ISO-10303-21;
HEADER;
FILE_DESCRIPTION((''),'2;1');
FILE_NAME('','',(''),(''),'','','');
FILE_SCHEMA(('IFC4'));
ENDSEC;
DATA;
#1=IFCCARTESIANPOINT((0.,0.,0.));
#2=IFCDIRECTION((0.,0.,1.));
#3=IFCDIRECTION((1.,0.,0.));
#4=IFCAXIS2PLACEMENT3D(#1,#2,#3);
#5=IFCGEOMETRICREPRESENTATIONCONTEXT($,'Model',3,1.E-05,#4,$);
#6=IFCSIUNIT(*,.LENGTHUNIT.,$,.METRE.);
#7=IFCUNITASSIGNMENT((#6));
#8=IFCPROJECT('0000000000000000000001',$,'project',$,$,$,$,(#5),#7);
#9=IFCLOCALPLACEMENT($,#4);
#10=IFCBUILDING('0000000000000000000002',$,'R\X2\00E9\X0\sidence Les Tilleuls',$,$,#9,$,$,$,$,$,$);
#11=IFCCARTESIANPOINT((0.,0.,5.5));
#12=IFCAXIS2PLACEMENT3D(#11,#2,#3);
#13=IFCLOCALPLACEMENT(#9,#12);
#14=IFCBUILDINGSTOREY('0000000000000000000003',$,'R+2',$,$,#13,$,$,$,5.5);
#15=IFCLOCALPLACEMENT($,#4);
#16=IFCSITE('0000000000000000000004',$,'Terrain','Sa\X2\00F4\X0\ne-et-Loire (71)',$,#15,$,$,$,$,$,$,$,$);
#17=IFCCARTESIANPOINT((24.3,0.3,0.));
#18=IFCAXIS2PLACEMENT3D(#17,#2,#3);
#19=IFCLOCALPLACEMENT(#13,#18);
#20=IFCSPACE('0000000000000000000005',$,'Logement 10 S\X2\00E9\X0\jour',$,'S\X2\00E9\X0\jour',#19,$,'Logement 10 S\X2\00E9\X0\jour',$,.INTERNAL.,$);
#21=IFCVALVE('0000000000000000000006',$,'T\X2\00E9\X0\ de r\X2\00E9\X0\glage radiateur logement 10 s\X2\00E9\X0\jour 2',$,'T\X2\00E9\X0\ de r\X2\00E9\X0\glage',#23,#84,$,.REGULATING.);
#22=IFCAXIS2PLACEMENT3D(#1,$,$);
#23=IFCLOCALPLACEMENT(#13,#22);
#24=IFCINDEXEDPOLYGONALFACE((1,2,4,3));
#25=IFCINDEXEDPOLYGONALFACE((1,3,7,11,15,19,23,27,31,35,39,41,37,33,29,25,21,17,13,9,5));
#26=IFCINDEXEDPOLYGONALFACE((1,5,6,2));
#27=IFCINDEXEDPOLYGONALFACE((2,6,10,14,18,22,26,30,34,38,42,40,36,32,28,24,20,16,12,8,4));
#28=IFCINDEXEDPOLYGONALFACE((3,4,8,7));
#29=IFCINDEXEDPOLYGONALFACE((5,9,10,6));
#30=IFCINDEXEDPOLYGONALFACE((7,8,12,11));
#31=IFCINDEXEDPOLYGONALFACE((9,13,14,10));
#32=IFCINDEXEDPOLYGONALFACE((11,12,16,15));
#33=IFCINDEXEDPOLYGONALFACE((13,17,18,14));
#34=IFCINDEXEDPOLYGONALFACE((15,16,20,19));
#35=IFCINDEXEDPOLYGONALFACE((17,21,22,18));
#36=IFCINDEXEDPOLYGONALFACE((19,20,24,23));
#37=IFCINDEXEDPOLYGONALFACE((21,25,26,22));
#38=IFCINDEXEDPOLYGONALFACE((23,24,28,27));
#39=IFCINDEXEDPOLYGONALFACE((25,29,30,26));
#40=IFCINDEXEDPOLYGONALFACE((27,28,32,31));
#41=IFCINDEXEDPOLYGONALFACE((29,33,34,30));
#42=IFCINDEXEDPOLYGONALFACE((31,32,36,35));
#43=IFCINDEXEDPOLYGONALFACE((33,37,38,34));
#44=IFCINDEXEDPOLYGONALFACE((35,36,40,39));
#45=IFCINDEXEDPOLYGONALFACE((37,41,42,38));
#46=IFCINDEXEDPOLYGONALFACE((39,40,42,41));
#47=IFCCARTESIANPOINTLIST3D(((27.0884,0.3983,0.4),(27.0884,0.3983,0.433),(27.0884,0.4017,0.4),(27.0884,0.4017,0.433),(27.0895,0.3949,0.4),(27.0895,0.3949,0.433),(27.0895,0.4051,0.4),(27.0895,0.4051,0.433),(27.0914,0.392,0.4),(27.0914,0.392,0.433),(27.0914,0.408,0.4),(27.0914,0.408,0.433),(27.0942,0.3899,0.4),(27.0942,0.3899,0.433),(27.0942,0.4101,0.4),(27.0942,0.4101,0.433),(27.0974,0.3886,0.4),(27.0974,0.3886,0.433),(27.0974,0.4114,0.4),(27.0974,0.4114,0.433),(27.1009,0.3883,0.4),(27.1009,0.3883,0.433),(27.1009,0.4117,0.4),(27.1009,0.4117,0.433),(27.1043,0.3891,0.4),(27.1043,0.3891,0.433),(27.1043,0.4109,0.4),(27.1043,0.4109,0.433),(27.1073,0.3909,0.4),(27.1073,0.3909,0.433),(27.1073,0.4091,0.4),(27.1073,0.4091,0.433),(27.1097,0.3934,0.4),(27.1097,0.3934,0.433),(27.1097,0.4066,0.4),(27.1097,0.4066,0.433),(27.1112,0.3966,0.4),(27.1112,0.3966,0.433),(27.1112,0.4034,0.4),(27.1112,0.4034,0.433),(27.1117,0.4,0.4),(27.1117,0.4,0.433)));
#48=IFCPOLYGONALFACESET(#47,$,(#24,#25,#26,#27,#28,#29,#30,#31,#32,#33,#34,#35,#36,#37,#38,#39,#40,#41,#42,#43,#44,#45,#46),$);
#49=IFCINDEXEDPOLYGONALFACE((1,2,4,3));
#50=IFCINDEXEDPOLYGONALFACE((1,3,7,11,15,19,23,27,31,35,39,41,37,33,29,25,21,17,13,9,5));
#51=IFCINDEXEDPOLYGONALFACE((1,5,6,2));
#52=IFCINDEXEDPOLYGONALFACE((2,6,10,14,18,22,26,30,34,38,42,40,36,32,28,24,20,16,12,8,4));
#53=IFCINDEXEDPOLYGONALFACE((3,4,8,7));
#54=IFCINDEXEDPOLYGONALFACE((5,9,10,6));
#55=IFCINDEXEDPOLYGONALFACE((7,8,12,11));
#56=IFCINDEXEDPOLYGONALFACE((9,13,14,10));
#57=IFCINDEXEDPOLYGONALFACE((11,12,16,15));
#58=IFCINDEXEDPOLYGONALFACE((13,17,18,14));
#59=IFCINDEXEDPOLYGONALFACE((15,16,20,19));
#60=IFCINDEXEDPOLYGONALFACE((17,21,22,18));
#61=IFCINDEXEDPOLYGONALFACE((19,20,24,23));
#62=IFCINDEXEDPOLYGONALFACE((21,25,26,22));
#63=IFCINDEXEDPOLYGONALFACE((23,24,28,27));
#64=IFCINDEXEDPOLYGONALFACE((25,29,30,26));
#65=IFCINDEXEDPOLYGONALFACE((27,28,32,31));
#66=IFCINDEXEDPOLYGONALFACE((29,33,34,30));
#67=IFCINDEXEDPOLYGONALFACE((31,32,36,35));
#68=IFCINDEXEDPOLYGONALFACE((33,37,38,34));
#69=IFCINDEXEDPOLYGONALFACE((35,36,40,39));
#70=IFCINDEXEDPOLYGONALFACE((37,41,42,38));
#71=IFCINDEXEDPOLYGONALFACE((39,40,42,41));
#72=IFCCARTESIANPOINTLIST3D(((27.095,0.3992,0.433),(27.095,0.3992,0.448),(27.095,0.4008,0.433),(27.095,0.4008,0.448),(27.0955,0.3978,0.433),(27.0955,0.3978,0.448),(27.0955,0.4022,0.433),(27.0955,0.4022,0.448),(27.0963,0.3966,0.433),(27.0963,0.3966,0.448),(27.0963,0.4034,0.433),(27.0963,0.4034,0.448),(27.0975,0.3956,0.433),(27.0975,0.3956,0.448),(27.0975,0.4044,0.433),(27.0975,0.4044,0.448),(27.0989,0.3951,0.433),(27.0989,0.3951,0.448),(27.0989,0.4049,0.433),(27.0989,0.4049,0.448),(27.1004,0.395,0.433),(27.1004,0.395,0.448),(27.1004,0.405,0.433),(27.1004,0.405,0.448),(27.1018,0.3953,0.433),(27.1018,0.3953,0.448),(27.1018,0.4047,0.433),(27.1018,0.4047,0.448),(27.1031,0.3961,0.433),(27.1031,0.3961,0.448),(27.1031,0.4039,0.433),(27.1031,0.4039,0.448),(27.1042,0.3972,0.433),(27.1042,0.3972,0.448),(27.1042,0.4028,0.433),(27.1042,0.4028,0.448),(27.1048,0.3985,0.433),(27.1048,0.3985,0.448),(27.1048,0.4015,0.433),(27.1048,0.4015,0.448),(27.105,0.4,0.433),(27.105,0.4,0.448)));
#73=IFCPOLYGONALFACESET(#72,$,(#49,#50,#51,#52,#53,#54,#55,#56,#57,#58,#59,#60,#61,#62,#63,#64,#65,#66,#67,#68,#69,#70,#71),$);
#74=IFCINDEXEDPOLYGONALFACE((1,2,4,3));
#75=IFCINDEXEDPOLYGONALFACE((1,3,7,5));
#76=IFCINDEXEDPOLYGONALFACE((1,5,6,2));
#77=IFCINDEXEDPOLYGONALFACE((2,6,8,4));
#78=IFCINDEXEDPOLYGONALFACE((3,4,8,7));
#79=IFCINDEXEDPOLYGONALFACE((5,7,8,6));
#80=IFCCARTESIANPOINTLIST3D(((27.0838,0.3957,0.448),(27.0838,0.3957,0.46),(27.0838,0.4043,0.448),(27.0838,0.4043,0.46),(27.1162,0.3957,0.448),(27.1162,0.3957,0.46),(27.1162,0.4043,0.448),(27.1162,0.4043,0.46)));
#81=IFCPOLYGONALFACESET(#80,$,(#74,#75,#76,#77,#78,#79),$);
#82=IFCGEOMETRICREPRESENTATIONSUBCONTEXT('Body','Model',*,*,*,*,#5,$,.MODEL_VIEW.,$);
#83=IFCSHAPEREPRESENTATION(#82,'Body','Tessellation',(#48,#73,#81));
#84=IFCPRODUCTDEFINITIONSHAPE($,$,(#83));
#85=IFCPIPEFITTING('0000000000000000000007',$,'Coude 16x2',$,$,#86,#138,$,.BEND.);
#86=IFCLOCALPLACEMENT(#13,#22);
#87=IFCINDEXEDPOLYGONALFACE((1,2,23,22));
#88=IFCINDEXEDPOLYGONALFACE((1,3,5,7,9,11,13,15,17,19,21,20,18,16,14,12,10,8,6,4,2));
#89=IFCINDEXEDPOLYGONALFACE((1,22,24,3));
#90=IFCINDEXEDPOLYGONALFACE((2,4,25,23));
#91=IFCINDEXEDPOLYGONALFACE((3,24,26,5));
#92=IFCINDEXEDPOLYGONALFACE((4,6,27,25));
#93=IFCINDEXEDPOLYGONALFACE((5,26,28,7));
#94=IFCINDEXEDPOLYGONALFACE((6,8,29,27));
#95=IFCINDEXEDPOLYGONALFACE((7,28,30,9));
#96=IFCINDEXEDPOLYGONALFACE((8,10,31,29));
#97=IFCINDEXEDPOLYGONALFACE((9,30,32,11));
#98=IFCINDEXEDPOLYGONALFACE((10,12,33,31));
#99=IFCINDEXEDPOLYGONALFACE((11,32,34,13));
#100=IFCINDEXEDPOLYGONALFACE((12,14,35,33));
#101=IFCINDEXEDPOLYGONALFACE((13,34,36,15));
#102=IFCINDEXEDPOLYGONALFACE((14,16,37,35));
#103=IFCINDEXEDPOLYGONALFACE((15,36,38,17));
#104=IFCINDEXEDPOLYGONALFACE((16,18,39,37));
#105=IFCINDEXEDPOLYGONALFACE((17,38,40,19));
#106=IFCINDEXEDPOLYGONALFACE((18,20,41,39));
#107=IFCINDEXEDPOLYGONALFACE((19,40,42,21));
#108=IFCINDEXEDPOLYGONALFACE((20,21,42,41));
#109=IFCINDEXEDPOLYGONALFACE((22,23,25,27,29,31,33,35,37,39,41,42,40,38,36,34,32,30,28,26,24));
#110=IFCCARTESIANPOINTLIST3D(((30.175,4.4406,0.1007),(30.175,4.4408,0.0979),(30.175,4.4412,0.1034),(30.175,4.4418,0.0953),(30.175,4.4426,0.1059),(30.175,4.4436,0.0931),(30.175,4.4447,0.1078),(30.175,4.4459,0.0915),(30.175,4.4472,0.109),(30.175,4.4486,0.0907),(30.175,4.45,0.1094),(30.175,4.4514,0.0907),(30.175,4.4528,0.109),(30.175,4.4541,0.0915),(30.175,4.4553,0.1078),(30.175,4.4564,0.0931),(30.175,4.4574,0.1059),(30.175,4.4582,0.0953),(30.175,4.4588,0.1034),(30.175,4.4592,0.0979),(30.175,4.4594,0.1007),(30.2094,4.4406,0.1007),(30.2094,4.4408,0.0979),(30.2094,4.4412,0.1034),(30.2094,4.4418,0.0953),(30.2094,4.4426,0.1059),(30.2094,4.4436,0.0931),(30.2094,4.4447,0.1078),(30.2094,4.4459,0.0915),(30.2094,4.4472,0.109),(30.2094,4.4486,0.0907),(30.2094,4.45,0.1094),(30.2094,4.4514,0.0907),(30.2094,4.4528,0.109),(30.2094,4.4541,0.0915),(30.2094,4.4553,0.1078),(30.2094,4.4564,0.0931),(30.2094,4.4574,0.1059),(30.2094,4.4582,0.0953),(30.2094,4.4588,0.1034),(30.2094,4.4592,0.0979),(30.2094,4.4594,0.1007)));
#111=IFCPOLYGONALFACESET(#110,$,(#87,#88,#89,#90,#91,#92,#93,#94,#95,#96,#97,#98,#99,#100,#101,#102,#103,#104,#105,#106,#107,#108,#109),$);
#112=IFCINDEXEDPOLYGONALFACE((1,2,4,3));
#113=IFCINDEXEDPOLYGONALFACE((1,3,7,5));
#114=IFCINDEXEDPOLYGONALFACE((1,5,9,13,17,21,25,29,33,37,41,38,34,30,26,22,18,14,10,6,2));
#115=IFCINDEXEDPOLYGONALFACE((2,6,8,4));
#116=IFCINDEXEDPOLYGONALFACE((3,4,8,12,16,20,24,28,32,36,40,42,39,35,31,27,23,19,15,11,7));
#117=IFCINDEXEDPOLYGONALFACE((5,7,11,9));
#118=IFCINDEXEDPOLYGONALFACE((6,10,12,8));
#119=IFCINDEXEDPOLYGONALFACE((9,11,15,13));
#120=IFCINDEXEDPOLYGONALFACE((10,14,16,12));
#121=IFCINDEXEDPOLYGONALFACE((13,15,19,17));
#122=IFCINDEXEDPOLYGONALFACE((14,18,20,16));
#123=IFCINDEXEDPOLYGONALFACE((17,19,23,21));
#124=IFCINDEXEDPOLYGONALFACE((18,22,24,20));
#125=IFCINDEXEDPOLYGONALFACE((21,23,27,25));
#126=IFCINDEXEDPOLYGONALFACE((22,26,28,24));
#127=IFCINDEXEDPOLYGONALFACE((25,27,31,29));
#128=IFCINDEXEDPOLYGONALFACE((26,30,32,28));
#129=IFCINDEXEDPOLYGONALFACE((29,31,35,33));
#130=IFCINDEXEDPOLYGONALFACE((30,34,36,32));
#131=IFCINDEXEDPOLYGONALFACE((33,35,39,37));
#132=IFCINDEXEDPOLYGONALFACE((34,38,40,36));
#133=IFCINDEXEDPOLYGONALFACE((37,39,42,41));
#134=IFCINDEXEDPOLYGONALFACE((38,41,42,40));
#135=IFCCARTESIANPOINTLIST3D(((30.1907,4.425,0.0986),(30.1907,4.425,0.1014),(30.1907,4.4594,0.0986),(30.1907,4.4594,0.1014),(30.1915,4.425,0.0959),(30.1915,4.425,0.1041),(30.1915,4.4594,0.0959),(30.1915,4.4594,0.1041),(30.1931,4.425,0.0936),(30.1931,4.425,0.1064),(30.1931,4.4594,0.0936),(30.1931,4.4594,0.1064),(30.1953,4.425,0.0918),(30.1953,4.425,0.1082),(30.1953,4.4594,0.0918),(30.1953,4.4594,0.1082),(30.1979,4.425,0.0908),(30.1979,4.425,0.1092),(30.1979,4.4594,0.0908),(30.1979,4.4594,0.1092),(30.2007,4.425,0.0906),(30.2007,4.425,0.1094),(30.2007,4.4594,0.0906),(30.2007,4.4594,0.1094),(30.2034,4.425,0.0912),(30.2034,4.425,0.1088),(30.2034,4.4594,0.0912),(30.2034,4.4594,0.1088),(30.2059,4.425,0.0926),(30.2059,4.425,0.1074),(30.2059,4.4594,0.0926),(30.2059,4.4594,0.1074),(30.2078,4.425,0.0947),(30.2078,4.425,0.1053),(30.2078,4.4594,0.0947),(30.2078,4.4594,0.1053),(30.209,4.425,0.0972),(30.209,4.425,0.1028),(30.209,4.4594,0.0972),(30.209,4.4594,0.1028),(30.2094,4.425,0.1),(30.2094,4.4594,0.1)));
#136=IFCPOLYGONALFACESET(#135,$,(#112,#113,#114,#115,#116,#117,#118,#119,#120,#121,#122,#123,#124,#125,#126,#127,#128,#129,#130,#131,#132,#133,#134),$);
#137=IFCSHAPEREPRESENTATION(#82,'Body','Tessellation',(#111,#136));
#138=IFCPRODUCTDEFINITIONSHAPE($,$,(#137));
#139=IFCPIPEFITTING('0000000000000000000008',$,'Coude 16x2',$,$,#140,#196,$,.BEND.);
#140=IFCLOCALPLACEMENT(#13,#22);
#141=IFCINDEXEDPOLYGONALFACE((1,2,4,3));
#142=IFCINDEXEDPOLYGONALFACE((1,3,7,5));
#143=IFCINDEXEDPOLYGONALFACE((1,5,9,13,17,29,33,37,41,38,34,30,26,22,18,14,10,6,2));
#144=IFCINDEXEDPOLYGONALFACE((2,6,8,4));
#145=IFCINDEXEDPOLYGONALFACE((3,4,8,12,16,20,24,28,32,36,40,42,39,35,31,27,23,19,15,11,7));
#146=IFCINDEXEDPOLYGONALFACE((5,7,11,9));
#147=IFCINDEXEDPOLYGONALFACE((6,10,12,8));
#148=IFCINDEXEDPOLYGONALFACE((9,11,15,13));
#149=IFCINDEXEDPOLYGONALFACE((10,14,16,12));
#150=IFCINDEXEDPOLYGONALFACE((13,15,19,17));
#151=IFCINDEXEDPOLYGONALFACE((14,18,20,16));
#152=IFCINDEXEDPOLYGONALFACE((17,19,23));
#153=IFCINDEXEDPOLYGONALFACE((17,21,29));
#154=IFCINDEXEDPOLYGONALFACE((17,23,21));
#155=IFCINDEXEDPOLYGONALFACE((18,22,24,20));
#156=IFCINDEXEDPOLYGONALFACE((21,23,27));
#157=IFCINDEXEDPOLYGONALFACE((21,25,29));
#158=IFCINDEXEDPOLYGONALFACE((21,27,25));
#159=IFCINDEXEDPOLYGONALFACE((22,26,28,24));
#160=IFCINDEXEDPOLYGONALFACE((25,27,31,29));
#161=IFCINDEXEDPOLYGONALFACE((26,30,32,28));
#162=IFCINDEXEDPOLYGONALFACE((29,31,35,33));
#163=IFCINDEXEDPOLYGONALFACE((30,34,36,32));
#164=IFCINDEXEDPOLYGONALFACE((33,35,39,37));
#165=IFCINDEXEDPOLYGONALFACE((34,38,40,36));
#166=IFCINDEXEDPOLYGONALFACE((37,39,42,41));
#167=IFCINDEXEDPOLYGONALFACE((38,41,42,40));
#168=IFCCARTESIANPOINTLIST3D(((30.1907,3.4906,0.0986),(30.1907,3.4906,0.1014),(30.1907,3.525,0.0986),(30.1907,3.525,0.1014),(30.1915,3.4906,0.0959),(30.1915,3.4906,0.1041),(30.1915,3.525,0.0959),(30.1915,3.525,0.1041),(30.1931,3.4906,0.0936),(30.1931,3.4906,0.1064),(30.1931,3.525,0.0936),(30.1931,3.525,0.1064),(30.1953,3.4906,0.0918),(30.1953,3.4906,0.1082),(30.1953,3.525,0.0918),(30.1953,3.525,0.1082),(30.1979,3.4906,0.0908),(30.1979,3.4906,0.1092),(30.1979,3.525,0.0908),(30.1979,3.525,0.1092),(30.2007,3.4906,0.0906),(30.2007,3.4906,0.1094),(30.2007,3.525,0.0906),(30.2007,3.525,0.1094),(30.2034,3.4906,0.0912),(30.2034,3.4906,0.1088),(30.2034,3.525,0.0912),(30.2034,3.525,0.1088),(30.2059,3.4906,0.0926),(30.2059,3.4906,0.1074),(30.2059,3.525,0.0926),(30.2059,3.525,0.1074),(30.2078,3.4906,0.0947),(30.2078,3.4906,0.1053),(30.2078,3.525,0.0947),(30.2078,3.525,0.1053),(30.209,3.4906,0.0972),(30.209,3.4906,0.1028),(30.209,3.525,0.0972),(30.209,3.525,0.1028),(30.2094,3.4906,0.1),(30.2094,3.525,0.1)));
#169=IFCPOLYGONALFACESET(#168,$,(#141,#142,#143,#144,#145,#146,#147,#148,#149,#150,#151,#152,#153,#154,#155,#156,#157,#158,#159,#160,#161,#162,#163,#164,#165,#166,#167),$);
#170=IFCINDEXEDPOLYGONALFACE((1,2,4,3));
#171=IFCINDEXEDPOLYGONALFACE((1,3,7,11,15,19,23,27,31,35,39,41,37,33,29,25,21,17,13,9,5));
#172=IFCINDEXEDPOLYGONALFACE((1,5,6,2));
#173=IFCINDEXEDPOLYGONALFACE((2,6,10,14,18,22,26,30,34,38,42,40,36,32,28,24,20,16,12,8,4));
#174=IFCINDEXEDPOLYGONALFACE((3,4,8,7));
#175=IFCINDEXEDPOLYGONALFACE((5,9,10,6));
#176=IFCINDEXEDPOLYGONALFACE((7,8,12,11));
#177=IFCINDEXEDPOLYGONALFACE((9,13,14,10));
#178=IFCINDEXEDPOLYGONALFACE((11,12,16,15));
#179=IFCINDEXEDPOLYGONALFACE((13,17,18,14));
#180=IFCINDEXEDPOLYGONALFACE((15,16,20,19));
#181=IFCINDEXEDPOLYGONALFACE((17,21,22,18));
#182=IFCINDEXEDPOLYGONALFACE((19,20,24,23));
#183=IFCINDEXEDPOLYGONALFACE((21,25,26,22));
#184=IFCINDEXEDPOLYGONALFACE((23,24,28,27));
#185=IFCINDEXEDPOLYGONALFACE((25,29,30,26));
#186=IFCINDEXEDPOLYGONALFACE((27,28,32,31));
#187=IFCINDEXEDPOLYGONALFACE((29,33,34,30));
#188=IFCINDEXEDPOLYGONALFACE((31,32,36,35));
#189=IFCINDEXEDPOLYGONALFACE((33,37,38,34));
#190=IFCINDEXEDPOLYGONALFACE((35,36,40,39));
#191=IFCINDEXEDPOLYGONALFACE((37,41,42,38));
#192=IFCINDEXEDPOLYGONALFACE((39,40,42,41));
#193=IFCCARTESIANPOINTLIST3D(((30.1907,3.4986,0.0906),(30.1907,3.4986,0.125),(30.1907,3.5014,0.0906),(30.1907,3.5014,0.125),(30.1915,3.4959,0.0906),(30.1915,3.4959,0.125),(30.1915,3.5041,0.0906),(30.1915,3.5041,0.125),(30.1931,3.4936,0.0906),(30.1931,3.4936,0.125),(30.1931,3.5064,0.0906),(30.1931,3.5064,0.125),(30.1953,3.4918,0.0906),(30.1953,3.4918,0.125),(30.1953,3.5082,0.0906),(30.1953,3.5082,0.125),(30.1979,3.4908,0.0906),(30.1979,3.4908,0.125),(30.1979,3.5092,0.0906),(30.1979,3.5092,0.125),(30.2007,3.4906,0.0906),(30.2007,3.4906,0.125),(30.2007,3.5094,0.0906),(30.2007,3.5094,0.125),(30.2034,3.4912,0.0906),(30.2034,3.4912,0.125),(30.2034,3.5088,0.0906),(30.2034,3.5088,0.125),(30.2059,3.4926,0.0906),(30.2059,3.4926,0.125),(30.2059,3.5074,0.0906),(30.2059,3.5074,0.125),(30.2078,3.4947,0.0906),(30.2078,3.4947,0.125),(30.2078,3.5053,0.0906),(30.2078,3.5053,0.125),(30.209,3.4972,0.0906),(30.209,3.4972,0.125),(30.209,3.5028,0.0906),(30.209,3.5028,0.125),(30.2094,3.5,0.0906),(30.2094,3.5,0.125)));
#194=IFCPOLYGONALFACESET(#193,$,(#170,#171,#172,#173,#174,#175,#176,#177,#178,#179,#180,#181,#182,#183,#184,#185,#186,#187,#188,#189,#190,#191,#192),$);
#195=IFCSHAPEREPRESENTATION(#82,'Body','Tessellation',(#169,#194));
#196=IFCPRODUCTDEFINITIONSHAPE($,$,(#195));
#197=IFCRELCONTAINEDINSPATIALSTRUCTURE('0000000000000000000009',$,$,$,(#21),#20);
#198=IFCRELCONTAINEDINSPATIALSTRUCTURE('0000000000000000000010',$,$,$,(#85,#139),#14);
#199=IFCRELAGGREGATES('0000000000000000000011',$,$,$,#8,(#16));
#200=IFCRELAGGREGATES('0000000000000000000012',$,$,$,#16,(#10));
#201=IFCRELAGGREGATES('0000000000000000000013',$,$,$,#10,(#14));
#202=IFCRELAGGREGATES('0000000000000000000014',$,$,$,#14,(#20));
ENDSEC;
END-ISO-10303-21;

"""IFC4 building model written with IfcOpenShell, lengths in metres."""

from ifc_helpers import new_model, si_unit, frame, frame_2d, origin_with_axes, place, context, subcontext, project, spatial, rectangle, circle, extrude, element, save


model = new_model("IFC4")

# Units and contexts
model_context = context("Model", 3, precision=1e-05, world=origin_with_axes())
body_context = subcontext(model_context, "Body", "Model", "MODEL_VIEW")
ifc_project = project(units=[si_unit("LENGTHUNIT", "METRE")], contexts=[model_context])

# Site, building, storey
site_placement = place(None, origin_with_axes())
site = spatial("IfcSite", under=ifc_project, at=site_placement, Name="Terrain", Description="Saône-et-Loire (71)")
building_placement = place(None, origin_with_axes())
building = spatial("IfcBuilding", under=site, at=building_placement, Name="Résidence Les Tilleuls")
storey_placement = place(building_placement, frame((0.0, 0.0, 5.5), z_axis=(0.0, 0.0, 1.0), x_axis=(1.0, 0.0, 0.0)))
storey = spatial("IfcBuildingStorey", under=building, at=storey_placement, Name="R+2", Elevation=5.5)

# Shared definitions
space_placement = place(storey_placement, frame((24.3, 0.3, 0.0), z_axis=(0.0, 0.0, 1.0), x_axis=(1.0, 0.0, 0.0)))
space = spatial("IfcSpace", under=storey, at=space_placement, Name="Logement 10 Séjour", ObjectType="Séjour", LongName="Logement 10 Séjour", PredefinedType="INTERNAL")

# Valve
valve_1_placement = place(space_placement, frame((2.8, 0.1, 0.4), z_axis=(0.0, 0.0, 1.0), x_axis=(1.0, 0.0, 0.0)))
element("IfcValve", 1, at=valve_1_placement, inside=space, Name="Té de réglage radiateur logement 10 séjour 2", ObjectType="Té de réglage", PredefinedType="REGULATING", context=body_context, shape_type="SweptSolid", body=[
    extrude(circle(Radius=0.0117), origin_with_axes(), (0.0, 0.0, 1.0), 0.033),
    extrude(circle(Radius=0.005), frame((0.0, 0.0, 0.033), z_axis=(0.0, 0.0, 1.0), x_axis=(1.0, 0.0, 0.0)), (0.0, 0.0, 1.0), 0.015),
    extrude(rectangle(XDim=0.0324, YDim=0.0086, at=frame_2d((0.0162, 0.0043))), frame((-0.0162, -0.0043, 0.048), z_axis=(0.0, 0.0, 1.0), x_axis=(1.0, 0.0, 0.0)), (0.0, 0.0, 1.0), 0.012),
])

# Pipe fittings
pipe_fitting_1_placement = place(storey_placement, frame((30.2, 4.45, 0.1), z_axis=(0.0, 0.0, 1.0), x_axis=(1.0, 0.0, 0.0)))
element("IfcPipeFitting", 2, at=pipe_fitting_1_placement, inside=storey, Name="Coude 16x2", PredefinedType="BEND", context=body_context, shape_type="SweptSolid", body=[
    extrude(circle(Radius=0.0094), frame((0.0094, 0.0, 0.0), z_axis=(-1.0, 0.0, 0.0), x_axis=(0.0, 0.0, 1.0)), (0.0, 0.0, 1.0), 0.0344),
    extrude(circle(Radius=0.0094), frame((0.0, 0.0094, 0.0), z_axis=(0.0, -1.0, 0.0), x_axis=(1.0, 0.0, 0.0)), (0.0, 0.0, 1.0), 0.0344),
])
pipe_fitting_2_placement = place(storey_placement, frame((30.2, 3.5, 0.1), z_axis=(0.0, 0.0, 1.0), x_axis=(1.0, 0.0, 0.0)))
element("IfcPipeFitting", 3, at=pipe_fitting_2_placement, inside=storey, Name="Coude 16x2", PredefinedType="BEND", context=body_context, shape_type="SweptSolid", body=[
    extrude(circle(Radius=0.0094), frame((0.0, -0.0094, 0.0), z_axis=(0.0, 1.0, 0.0), x_axis=(1.0, 0.0, 0.0)), (0.0, 0.0, 1.0), 0.0344),
    extrude(circle(Radius=0.0094), frame((0.0, 0.0, -0.0094), z_axis=(0.0, 0.0, 1.0), x_axis=(1.0, 0.0, 0.0)), (0.0, 0.0, 1.0), 0.0344),
])

save(model, "model.ifc")
